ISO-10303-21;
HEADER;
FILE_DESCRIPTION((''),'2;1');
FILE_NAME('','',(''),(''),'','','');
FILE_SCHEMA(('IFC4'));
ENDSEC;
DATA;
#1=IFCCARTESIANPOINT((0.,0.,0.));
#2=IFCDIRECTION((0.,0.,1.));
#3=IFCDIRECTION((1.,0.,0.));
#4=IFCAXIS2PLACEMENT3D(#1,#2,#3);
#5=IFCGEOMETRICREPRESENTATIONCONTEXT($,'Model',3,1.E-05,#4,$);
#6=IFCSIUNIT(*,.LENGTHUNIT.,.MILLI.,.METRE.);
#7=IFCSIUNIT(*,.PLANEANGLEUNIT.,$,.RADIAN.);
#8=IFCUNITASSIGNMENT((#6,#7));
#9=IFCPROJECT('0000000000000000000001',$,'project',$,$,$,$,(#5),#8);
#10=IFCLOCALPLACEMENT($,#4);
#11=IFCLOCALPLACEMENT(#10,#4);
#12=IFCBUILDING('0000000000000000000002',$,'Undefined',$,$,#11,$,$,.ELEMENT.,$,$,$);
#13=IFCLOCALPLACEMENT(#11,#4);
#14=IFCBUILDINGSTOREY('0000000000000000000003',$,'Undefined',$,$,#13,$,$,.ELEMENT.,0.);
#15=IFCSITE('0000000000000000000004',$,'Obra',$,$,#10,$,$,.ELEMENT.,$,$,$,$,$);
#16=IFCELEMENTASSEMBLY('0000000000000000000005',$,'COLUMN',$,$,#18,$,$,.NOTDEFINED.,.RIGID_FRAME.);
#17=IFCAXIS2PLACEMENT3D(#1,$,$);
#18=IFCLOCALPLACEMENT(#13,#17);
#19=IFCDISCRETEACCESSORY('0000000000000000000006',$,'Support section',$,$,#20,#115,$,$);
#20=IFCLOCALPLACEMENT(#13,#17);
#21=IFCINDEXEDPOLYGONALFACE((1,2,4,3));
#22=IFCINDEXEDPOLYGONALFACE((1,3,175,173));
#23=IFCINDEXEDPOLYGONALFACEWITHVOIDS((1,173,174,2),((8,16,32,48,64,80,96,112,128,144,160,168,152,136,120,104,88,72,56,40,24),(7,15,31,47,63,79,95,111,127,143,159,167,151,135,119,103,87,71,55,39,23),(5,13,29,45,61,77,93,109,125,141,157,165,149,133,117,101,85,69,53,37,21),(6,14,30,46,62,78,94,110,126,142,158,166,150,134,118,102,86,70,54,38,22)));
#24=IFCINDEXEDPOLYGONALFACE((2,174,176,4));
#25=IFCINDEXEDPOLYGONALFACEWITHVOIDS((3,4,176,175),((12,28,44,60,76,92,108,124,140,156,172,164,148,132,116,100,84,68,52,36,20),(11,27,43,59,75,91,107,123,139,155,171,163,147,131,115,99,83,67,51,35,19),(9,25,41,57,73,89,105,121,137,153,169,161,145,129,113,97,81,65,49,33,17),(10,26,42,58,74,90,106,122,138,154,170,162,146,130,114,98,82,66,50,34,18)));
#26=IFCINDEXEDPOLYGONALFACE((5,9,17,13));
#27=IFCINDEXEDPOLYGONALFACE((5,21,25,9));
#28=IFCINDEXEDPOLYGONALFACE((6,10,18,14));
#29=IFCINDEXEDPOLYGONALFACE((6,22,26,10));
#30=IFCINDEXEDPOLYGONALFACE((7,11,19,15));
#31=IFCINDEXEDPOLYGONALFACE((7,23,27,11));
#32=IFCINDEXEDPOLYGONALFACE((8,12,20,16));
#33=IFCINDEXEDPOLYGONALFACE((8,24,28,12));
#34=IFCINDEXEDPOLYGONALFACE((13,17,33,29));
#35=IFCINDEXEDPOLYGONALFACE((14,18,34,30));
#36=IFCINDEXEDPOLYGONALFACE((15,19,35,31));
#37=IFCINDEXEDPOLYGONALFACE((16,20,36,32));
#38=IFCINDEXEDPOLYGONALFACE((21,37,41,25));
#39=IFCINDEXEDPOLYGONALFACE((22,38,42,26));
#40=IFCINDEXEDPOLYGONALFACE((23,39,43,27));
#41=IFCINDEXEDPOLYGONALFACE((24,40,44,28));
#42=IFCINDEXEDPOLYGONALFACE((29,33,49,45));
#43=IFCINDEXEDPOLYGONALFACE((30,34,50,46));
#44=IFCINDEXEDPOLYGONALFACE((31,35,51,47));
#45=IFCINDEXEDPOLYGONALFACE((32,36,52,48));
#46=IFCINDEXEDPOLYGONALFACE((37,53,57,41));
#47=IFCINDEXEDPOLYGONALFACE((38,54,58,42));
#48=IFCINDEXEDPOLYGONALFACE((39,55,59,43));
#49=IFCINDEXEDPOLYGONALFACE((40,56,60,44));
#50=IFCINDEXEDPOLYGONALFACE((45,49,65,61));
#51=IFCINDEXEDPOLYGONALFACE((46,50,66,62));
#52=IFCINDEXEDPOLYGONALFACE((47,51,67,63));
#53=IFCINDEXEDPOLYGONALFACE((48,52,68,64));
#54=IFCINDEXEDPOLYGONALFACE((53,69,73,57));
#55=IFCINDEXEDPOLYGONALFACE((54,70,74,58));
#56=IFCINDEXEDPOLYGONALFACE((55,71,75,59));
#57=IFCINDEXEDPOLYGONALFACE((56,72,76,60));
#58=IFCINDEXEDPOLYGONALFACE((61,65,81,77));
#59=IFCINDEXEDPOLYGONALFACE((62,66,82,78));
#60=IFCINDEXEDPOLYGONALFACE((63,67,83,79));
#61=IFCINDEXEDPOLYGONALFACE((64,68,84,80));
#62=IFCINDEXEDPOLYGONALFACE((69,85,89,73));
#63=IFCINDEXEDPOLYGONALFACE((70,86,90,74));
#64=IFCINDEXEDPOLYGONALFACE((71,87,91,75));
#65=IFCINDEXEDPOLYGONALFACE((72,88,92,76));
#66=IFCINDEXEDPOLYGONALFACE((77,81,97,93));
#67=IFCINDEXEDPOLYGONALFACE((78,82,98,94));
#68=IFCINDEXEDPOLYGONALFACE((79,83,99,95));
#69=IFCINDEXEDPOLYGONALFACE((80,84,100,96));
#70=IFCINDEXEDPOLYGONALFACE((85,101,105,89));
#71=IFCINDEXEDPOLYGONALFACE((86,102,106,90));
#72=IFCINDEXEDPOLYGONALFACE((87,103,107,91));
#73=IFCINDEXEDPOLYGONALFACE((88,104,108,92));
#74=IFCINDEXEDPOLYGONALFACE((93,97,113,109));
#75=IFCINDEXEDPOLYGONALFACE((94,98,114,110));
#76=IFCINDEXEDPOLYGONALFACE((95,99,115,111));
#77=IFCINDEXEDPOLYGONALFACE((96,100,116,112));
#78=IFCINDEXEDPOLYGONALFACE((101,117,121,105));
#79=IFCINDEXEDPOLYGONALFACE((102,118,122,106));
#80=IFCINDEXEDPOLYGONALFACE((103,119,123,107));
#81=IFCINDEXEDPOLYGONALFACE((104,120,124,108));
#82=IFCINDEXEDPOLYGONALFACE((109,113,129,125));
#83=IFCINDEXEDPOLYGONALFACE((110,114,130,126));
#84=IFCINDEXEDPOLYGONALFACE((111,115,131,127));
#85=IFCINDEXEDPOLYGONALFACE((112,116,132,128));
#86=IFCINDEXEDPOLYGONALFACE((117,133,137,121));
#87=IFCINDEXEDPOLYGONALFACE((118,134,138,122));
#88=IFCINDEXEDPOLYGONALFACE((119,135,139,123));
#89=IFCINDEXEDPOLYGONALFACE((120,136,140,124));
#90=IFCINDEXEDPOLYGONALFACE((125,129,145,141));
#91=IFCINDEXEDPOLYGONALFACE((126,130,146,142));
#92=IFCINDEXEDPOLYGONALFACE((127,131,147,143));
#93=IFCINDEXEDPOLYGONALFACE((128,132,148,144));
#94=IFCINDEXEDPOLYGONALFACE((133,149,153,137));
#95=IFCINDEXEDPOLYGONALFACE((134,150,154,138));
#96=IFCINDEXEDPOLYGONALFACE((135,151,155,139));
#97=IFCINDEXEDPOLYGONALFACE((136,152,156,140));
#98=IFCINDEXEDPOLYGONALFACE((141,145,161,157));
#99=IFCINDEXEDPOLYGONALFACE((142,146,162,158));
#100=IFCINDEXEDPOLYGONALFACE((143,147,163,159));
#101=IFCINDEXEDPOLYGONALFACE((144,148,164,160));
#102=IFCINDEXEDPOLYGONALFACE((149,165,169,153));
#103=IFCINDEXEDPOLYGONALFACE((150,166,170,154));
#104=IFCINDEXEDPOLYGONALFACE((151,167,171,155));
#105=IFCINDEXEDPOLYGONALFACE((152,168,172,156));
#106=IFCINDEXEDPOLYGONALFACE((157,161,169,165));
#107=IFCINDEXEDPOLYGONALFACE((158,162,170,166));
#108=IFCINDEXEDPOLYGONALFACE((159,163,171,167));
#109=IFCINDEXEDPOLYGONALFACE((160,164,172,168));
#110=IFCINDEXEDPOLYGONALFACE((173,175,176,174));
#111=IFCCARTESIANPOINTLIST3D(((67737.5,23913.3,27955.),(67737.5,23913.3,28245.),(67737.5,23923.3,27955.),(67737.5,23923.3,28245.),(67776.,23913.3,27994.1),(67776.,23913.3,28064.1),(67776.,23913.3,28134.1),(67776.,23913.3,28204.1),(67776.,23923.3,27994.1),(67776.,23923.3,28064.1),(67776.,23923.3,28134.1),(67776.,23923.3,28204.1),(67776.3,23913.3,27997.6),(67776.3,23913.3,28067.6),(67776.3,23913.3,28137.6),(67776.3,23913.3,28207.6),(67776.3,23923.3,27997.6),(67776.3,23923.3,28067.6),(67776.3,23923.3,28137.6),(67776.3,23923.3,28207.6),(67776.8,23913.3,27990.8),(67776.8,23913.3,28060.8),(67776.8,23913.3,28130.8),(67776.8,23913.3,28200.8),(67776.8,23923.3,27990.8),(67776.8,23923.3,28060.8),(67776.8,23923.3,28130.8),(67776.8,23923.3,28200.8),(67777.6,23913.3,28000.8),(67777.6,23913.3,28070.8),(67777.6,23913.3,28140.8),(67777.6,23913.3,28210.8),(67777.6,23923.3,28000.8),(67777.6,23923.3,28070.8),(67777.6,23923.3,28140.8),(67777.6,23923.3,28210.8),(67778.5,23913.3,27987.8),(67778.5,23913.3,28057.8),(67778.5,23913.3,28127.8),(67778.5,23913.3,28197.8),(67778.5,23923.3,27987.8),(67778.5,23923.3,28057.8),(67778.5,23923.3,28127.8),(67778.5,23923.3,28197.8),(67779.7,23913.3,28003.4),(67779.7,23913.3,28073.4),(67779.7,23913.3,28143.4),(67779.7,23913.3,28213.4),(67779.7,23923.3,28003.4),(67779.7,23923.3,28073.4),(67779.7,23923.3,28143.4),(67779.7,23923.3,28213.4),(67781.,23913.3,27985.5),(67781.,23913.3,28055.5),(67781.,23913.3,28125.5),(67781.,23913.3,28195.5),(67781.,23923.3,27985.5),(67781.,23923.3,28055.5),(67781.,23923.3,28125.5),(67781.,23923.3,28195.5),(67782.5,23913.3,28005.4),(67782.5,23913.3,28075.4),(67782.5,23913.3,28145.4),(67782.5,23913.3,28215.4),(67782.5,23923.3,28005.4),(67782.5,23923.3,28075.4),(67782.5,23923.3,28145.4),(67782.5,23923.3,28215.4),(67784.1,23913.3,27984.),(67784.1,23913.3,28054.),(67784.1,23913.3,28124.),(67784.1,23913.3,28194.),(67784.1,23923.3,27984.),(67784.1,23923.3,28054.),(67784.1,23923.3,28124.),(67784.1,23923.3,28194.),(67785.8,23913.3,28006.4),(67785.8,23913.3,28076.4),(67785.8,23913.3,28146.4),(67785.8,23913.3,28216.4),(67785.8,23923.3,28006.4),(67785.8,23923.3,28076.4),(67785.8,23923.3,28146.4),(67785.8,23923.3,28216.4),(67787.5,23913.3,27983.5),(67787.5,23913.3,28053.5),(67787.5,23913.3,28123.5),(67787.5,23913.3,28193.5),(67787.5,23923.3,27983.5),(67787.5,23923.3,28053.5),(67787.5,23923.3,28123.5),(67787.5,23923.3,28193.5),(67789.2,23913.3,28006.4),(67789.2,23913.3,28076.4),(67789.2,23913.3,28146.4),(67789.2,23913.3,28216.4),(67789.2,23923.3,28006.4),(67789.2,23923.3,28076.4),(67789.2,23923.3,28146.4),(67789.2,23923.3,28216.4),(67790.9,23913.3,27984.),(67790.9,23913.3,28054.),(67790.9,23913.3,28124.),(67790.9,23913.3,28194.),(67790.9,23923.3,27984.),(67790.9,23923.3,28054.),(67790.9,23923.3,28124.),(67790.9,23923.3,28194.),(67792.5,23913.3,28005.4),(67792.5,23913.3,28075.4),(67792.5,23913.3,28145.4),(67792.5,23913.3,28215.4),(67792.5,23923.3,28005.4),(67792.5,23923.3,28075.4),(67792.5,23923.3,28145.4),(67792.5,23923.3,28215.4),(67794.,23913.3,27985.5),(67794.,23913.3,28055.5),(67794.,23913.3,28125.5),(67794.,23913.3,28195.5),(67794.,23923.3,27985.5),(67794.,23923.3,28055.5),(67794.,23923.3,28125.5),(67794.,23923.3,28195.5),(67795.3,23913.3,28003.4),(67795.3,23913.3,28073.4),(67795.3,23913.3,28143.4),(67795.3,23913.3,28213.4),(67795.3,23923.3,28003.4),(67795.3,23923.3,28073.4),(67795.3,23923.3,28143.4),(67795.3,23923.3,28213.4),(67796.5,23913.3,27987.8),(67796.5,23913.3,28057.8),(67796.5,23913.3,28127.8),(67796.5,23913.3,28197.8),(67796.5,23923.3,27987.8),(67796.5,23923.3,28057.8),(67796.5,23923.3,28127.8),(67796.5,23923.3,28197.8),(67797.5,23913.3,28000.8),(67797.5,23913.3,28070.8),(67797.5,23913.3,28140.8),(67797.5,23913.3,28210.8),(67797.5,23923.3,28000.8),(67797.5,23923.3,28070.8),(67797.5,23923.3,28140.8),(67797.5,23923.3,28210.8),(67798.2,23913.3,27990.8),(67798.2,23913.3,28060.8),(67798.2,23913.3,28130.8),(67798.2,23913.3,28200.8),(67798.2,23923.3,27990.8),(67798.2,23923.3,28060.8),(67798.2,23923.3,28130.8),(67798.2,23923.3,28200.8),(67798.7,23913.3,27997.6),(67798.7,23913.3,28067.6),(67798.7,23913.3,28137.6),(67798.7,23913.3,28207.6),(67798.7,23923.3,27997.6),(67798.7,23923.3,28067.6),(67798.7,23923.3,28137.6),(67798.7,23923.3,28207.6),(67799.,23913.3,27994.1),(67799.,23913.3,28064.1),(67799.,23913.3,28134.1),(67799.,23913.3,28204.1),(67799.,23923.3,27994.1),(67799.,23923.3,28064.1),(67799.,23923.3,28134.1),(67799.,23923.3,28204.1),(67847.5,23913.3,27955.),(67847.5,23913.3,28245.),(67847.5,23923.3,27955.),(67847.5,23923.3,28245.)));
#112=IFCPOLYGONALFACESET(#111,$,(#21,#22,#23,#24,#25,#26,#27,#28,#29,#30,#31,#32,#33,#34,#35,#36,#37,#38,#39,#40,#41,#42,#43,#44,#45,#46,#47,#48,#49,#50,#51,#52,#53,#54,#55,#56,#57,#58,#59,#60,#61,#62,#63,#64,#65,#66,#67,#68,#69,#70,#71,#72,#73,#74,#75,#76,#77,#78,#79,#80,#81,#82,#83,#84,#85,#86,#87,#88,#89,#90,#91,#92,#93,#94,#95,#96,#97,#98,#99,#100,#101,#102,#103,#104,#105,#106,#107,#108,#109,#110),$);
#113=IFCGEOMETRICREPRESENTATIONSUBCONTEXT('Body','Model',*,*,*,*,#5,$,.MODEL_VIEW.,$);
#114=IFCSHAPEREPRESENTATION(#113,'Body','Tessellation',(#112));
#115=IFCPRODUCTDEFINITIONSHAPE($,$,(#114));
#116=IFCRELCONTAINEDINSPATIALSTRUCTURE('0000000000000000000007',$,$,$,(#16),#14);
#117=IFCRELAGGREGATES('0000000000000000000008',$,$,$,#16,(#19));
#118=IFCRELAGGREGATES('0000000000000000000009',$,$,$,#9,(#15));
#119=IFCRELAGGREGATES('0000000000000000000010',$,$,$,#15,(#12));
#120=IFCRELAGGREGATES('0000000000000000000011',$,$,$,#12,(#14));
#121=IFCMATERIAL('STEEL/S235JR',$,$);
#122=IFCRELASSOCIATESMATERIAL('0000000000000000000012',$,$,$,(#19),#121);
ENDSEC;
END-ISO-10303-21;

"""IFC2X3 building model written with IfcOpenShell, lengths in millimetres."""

from ifc_helpers import new_model, si_unit, frame, origin_with_axes, origin_2d_with_axis, place, context, subcontext, project, spatial, rectangle, circle, extrude, source, transform, mapped, material, element, aggregate, save


model = new_model("IFC2X3")

# Units and contexts
model_context = context("Model", 3, precision=1e-05, world=origin_with_axes())
body_context = subcontext(model_context, "Body", "Model", "MODEL_VIEW")
ifc_project = project(units=[si_unit("LENGTHUNIT", "METRE", prefix="MILLI"), si_unit("PLANEANGLEUNIT", "RADIAN")], contexts=[model_context])

# Site, building, storey
site_placement = place(None, origin_with_axes())
site = spatial("IfcSite", under=ifc_project, at=site_placement, Name="Obra", CompositionType="ELEMENT")
building_placement = place(site_placement, origin_with_axes())
building = spatial("IfcBuilding", under=site, at=building_placement, Name="Undefined", CompositionType="ELEMENT")
storey_placement = place(building_placement, origin_with_axes())
storey = spatial("IfcBuildingStorey", under=building, at=storey_placement, Name="Undefined", CompositionType="ELEMENT", Elevation=0.0)

# Element assembly
assembly_1_placement = place(storey_placement, origin_with_axes())
assembly_1 = element("IfcElementAssembly", 1, at=assembly_1_placement, inside=storey, Name="COLUMN", AssemblyPlace="NOTDEFINED", PredefinedType="RIGID_FRAME")
ifc_material_1 = material(Name="STEEL/S235JR")

# Discrete accessory, opening
shared_shape_1 = source(origin_with_axes(), body_context, "Body", "SweptSolid", [
    extrude(circle(Radius=11.5, at=origin_2d_with_axis()), frame((0.0, -14.4, 0.0), z_axis=(0.0, 1.0, 0.0), x_axis=(1.0, 0.0, 0.0)), (0.0, 0.0, 1.0), 10.2),
])
discrete_accessory_1_placement = place(assembly_1_placement, frame((67792.5, 23918.3, 27955.0), z_axis=(0.0, 0.0, 1.0), x_axis=(1.0, 0.0, 0.0)))
discrete_accessory_1 = element("IfcDiscreteAccessory", 2, at=discrete_accessory_1_placement, material=ifc_material_1, Name="Support section", context=body_context, shape_type="SweptSolid", body=[
    extrude(rectangle(XDim=10.0, YDim=110.0, at=origin_2d_with_axis()), frame((0.0, 0.0, 290.0), z_axis=(0.0, 0.0, -1.0), x_axis=(0.0, 1.0, 0.0)), (0.0, 0.0, 1.0), 290.0),
])
opening_1_placement = place(assembly_1_placement, frame((67837.5, 23909.0, 28300.0), z_axis=(-1.0, 0.0, 0.0), x_axis=(0.0, 0.0, -1.0)))
element("IfcOpeningElement", 3, at=opening_1_placement, cuts=discrete_accessory_1, ObjectType="Opening", context=body_context, shape_type="MappedRepresentation", body=[
    mapped(shared_shape_1, transform((95.0, 0.0, 50.0))),
    mapped(shared_shape_1, transform((165.0, 0.0, 50.0))),
    mapped(shared_shape_1, transform((235.0, 0.0, 50.0))),
    mapped(shared_shape_1, transform((305.0, 0.0, 50.0))),
])
aggregate(assembly_1, [discrete_accessory_1])

save(model, "model.ifc")
